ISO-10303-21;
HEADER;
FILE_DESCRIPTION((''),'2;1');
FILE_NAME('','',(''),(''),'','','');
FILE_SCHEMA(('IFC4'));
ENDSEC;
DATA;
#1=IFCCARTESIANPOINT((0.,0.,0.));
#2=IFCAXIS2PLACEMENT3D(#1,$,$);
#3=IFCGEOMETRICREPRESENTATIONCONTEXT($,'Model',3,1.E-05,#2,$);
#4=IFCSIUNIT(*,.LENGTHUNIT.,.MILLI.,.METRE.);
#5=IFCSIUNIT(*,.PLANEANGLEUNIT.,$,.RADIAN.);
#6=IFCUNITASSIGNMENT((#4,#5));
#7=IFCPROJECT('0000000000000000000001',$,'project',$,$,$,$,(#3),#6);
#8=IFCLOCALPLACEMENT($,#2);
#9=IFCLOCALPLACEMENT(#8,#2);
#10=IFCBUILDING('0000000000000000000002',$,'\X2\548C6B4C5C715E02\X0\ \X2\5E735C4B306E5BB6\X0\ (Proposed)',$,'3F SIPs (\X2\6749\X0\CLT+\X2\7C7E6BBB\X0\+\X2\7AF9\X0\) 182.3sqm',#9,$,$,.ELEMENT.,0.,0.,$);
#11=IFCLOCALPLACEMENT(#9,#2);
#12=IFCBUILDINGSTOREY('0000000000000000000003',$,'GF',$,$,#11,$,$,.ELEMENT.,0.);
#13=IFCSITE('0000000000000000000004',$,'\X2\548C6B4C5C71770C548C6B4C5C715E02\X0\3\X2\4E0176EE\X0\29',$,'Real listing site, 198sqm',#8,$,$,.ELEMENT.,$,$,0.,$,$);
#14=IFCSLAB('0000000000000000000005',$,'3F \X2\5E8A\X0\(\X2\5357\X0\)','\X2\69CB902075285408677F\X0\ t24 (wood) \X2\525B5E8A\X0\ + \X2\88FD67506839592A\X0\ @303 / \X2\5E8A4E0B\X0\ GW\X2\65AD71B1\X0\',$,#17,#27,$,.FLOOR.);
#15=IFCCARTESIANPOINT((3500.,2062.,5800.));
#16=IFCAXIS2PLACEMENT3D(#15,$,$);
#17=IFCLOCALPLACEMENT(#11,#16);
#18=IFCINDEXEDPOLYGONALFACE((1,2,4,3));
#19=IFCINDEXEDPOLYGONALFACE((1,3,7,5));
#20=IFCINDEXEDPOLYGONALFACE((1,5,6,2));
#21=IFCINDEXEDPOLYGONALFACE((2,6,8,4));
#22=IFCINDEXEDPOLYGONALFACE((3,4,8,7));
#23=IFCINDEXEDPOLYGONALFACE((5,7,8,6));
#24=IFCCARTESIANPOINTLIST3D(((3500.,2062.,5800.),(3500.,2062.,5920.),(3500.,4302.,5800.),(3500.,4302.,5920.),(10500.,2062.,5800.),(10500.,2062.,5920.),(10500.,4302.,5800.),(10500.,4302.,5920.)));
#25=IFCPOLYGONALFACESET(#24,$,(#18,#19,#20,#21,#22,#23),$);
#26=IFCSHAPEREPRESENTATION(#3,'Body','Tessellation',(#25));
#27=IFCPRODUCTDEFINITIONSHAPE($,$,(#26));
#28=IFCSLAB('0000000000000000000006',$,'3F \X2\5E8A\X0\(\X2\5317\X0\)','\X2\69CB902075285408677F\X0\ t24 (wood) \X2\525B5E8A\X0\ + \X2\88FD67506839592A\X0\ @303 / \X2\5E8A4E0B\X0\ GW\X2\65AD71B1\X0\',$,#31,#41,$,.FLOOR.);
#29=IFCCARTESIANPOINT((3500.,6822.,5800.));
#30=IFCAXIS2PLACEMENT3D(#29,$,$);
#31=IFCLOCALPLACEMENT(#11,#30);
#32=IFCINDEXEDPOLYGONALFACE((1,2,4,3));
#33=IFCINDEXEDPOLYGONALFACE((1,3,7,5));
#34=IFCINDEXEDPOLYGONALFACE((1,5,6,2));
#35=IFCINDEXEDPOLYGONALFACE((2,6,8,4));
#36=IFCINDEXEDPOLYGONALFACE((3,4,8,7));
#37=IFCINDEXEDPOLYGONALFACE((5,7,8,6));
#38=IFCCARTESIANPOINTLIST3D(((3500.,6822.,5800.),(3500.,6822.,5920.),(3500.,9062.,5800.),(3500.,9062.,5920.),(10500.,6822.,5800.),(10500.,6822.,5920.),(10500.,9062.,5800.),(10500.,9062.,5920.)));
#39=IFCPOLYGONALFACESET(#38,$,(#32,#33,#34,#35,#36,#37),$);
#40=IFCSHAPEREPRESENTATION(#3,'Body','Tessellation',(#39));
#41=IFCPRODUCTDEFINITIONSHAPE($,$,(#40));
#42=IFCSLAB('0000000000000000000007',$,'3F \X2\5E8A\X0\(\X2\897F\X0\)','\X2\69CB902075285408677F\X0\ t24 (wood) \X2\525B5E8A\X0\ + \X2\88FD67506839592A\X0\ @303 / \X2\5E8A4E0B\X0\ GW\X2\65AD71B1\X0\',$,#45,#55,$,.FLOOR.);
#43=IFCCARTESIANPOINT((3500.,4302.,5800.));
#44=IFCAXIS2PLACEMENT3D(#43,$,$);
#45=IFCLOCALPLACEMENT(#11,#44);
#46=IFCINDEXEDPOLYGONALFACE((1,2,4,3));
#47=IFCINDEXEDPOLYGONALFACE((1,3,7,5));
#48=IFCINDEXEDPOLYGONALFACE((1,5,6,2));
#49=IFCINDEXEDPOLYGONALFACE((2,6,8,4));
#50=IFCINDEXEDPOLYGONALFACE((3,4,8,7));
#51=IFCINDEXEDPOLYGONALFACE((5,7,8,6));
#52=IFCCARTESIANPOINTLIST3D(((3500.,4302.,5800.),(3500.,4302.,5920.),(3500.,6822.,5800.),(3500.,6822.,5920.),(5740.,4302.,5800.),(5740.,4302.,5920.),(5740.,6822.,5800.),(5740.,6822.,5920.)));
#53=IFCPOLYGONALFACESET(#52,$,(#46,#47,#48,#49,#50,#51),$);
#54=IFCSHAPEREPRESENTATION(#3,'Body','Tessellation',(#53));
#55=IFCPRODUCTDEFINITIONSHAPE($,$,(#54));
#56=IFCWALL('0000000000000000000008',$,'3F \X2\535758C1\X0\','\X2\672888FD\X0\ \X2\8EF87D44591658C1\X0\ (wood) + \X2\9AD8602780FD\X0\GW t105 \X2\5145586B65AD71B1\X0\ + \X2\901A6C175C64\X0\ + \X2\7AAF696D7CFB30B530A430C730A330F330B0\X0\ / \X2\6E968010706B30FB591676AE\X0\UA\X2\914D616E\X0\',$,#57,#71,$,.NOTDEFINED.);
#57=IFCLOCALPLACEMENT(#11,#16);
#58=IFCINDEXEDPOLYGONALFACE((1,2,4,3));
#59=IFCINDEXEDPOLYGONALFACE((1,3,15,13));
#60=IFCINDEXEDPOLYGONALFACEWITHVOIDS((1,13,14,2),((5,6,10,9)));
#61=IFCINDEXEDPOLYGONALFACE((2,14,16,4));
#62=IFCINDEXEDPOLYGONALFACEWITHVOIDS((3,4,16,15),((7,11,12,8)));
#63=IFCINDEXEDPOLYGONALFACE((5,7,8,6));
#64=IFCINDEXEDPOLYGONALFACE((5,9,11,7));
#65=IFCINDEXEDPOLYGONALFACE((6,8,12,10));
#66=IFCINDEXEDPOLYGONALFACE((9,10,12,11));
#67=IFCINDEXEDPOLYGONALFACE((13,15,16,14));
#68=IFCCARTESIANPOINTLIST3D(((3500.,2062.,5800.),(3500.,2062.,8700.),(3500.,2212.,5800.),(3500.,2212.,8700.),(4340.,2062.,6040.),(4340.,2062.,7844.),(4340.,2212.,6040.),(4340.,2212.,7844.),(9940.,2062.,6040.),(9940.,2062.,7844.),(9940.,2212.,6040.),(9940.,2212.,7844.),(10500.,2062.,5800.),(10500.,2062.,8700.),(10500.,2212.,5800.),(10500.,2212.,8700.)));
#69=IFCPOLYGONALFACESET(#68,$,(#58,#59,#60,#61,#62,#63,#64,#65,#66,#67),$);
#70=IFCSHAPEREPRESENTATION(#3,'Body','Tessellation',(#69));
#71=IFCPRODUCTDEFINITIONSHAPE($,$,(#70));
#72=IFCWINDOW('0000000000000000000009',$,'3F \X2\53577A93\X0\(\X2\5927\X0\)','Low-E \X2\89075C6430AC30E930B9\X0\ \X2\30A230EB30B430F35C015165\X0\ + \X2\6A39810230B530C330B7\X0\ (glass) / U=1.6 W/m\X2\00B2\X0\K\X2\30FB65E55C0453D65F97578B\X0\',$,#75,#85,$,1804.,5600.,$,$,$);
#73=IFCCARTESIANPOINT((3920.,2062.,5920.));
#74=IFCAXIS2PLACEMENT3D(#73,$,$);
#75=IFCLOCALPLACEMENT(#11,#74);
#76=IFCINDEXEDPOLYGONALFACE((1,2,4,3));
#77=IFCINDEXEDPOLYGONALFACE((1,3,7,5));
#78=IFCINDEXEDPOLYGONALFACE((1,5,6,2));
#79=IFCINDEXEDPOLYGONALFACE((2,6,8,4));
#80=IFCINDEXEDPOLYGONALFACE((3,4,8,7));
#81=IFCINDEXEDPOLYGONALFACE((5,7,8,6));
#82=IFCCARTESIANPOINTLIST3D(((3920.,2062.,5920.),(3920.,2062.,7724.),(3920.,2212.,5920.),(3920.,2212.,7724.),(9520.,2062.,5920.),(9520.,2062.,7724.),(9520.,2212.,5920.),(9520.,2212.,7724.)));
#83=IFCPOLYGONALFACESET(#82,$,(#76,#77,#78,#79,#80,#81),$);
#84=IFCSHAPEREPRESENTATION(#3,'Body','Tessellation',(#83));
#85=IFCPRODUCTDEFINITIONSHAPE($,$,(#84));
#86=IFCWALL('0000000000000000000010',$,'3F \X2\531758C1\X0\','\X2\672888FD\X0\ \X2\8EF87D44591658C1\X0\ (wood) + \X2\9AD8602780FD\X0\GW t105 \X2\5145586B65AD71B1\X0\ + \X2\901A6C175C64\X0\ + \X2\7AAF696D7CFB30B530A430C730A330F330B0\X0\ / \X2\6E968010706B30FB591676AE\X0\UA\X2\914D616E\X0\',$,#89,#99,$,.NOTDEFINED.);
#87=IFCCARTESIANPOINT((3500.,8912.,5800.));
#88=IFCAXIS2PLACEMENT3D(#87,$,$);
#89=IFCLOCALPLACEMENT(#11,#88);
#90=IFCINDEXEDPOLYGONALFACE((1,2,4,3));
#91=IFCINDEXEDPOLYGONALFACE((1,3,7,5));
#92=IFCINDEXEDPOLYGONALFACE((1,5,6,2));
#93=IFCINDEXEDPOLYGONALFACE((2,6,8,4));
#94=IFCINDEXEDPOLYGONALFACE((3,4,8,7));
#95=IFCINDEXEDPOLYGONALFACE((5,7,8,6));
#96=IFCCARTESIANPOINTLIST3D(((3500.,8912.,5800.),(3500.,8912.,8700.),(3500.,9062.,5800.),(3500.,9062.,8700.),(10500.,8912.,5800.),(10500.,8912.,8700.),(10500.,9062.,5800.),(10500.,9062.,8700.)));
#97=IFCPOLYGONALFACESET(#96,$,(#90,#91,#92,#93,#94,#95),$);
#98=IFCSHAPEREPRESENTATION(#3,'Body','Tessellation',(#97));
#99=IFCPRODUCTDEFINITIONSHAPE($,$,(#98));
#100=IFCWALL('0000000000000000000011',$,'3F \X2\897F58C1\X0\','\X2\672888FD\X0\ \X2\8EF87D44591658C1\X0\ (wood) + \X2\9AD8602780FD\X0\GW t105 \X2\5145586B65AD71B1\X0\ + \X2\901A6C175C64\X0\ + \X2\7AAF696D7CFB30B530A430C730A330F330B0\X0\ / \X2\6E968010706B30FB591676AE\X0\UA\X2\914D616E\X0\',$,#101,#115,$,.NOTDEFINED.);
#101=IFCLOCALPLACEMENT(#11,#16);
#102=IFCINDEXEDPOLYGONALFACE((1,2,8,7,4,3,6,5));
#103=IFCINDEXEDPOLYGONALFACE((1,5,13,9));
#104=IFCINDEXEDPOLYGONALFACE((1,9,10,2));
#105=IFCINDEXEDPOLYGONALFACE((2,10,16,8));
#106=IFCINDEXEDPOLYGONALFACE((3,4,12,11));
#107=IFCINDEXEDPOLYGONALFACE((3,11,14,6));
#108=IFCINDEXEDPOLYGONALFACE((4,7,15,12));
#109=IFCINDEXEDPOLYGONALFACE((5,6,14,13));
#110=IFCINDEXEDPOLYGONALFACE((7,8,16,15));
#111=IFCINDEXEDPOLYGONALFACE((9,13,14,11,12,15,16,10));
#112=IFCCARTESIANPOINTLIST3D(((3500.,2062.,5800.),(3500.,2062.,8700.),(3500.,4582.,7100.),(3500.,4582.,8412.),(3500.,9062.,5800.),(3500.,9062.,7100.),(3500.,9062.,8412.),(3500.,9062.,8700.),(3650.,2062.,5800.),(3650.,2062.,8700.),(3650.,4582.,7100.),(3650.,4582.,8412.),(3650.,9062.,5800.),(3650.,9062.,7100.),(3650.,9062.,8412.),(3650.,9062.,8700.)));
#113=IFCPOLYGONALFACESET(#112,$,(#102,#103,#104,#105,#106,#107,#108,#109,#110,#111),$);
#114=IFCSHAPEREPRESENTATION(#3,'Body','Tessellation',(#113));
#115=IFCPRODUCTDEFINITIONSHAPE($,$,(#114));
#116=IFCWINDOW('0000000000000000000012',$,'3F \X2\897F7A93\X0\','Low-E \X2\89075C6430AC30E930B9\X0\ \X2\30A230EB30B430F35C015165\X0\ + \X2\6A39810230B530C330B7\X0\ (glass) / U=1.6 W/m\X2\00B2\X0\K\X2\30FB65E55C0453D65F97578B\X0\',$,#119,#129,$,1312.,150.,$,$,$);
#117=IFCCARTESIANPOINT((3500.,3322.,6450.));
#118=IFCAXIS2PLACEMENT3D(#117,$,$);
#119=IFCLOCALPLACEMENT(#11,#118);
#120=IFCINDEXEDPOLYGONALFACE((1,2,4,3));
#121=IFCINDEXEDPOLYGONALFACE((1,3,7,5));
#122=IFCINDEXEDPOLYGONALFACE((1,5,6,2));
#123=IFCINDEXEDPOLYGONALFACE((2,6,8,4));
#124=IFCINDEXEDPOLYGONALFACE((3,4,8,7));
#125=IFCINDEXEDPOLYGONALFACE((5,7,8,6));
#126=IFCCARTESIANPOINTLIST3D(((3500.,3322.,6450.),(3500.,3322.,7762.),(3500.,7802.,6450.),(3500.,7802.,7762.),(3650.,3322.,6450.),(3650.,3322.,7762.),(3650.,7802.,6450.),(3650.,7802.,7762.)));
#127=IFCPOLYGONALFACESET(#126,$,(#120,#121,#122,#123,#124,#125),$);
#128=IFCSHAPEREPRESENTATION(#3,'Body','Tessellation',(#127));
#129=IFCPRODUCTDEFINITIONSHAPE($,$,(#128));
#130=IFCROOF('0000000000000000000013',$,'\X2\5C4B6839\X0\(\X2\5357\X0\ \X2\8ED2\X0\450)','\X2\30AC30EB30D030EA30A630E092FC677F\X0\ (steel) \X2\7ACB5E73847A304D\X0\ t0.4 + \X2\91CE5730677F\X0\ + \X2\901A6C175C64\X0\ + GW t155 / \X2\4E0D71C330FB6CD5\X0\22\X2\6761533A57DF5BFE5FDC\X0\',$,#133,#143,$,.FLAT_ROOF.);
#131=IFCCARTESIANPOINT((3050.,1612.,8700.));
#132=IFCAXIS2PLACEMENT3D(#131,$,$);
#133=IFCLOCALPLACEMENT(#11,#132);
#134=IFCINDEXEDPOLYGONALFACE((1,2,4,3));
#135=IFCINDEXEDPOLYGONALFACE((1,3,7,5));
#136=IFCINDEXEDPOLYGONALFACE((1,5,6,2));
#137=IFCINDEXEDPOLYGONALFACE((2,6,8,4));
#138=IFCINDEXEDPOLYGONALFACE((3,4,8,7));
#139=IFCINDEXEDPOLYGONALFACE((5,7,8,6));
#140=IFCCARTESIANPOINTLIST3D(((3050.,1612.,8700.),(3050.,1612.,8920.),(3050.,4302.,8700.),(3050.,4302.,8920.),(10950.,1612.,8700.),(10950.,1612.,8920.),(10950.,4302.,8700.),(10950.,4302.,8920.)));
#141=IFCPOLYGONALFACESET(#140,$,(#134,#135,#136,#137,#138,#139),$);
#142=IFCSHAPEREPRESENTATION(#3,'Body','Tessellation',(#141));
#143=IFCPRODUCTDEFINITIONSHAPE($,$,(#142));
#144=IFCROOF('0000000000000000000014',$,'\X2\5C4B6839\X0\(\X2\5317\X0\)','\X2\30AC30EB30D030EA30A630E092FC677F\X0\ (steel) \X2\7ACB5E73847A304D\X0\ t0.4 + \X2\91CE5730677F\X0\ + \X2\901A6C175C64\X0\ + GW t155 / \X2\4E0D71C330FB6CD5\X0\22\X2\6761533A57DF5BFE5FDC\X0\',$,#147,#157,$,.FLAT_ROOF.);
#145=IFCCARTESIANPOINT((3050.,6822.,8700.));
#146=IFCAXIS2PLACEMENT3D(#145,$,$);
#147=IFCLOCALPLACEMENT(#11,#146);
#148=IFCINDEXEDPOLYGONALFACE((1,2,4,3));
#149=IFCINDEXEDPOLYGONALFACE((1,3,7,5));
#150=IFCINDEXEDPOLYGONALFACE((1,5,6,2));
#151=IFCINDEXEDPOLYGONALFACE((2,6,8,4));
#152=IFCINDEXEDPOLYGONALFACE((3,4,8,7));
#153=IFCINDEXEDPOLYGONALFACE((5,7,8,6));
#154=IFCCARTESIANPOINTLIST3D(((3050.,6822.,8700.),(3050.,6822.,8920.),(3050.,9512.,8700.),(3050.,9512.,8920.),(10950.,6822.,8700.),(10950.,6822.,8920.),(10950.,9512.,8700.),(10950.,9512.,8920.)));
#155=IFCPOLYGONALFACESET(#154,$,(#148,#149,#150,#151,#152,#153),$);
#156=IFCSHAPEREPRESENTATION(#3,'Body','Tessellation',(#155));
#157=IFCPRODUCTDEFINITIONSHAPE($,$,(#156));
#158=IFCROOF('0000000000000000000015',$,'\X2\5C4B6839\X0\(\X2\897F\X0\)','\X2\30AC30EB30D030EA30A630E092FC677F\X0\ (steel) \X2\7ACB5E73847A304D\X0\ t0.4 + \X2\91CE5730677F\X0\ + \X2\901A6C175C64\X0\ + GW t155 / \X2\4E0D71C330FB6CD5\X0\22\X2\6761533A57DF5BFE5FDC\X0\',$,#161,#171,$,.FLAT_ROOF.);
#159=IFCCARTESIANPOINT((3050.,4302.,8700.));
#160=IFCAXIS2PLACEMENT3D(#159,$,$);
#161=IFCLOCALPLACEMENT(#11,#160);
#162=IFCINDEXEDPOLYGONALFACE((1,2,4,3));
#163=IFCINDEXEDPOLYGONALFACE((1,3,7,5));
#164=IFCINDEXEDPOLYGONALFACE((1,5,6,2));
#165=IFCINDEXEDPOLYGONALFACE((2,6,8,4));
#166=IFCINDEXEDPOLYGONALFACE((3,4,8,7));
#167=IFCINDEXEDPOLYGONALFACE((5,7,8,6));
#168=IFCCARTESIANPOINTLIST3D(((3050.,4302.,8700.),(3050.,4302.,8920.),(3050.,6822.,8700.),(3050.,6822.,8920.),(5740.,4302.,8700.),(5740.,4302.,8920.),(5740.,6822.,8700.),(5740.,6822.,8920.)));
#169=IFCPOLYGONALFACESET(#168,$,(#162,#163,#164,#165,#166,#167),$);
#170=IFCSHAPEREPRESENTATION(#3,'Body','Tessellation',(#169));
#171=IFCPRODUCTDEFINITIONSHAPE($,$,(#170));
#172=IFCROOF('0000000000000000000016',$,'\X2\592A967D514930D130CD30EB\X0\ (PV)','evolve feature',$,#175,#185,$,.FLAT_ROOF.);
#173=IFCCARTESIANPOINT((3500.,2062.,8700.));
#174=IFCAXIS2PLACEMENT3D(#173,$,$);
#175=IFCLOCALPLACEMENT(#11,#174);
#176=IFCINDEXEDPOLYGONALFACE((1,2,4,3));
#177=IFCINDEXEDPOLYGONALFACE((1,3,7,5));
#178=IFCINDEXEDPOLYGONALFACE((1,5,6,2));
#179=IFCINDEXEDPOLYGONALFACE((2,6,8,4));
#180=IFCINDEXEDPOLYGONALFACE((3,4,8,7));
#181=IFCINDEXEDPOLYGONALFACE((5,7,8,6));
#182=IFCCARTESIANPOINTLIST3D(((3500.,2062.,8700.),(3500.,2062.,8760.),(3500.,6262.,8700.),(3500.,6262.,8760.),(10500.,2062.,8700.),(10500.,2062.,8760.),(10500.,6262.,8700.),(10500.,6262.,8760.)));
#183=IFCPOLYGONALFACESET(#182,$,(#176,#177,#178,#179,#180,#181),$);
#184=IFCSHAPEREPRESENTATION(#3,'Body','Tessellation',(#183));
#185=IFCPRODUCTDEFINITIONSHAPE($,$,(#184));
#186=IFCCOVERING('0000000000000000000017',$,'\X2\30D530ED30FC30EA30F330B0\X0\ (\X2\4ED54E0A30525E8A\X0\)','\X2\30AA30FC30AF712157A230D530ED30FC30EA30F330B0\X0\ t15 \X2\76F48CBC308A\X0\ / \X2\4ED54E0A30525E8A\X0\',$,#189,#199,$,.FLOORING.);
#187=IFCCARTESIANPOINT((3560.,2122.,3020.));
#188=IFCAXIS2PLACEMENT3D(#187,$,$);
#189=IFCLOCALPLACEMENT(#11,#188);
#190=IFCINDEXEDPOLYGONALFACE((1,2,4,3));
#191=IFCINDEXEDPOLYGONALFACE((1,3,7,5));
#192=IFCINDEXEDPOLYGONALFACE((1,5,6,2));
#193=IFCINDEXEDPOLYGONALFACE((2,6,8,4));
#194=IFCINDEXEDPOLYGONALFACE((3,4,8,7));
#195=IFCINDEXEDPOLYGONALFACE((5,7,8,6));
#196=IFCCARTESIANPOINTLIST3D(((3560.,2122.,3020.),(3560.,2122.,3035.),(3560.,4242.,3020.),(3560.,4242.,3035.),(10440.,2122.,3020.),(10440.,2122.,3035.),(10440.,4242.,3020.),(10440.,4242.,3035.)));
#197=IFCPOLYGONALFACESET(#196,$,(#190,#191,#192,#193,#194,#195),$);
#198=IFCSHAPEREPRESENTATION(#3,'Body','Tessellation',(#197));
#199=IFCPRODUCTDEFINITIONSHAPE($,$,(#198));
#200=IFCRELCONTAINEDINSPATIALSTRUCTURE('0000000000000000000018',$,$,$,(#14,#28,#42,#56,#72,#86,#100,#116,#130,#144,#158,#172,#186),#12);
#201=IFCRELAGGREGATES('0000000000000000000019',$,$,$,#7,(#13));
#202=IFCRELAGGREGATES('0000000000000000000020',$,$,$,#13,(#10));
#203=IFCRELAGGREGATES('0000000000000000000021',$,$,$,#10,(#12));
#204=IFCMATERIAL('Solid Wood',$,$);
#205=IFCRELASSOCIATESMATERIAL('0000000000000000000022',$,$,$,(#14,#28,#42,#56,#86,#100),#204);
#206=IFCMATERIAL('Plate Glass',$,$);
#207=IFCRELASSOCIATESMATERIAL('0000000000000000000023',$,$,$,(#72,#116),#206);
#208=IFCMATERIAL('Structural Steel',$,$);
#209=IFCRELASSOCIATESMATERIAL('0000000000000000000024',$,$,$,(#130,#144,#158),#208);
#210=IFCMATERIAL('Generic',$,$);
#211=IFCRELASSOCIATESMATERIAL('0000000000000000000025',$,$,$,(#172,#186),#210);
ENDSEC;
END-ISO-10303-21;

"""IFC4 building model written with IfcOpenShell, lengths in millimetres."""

from ifc_helpers import new_model, si_unit, frame, frame_2d, origin, place, context, project, spatial, rectangle, extrude, material, element, fill, save


model = new_model("IFC4")

# Units and contexts
model_context = context("Model", 3, precision=1e-05, world=origin())
ifc_project = project(units=[si_unit("LENGTHUNIT", "METRE", prefix="MILLI"), si_unit("PLANEANGLEUNIT", "RADIAN")], contexts=[model_context])

# Site, building, storey
site_placement = place(None, origin())
site = spatial("IfcSite", under=ifc_project, at=site_placement, Name="和歌山県和歌山市3丁目29", ObjectType="Real listing site, 198sqm", CompositionType="ELEMENT", RefElevation=0.0)
building_placement = place(site_placement, origin())
building = spatial("IfcBuilding", under=site, at=building_placement, Name="和歌山市 平屋の家 (Proposed)", ObjectType="3F SIPs (杉CLT+籾殻+竹) 182.3sqm", CompositionType="ELEMENT", ElevationOfRefHeight=0.0, ElevationOfTerrain=0.0)
storey_placement = place(building_placement, origin())
storey = spatial("IfcBuildingStorey", under=building, at=storey_placement, Name="GF", CompositionType="ELEMENT", Elevation=0.0)

# Slabs
ifc_material_1 = material(Name="Solid Wood")
slab_1_placement = place(storey_placement, frame((3500.0, 2062.0, 5800.0)))
element("IfcSlab", 1, at=slab_1_placement, inside=storey, material=ifc_material_1, Name="3F 床(南)", Description="構造用合板 t24 (wood) 剛床 + 製材根太 @303 / 床下 GW断熱", PredefinedType="FLOOR", context=model_context, shape_type="SweptSolid", body=[
    extrude(rectangle(XDim=7000.0, YDim=2240.0, at=frame_2d((3500.0, 1120.0))), frame((3500.0, 2062.0, 5800.0)), (0.0, 0.0, 1.0), 120.0),
])
slab_2_placement = place(storey_placement, frame((3500.0, 6822.0, 5800.0)))
element("IfcSlab", 2, at=slab_2_placement, inside=storey, material=ifc_material_1, Name="3F 床(北)", Description="構造用合板 t24 (wood) 剛床 + 製材根太 @303 / 床下 GW断熱", PredefinedType="FLOOR", context=model_context, shape_type="SweptSolid", body=[
    extrude(rectangle(XDim=7000.0, YDim=2240.0, at=frame_2d((3500.0, 1120.0))), frame((3500.0, 6822.0, 5800.0)), (0.0, 0.0, 1.0), 120.0),
])
slab_3_placement = place(storey_placement, frame((3500.0, 4302.0, 5800.0)))
element("IfcSlab", 3, at=slab_3_placement, inside=storey, material=ifc_material_1, Name="3F 床(西)", Description="構造用合板 t24 (wood) 剛床 + 製材根太 @303 / 床下 GW断熱", PredefinedType="FLOOR", context=model_context, shape_type="SweptSolid", body=[
    extrude(rectangle(XDim=2240.0, YDim=2520.0, at=frame_2d((1120.0, 1260.0))), frame((3500.0, 4302.0, 5800.0)), (0.0, 0.0, 1.0), 120.0),
])

# Wall, opening, window
wall_1_placement = place(storey_placement, frame((3500.0, 2062.0, 5800.0)))
wall_1 = element("IfcWall", 4, at=wall_1_placement, inside=storey, material=ifc_material_1, Name="3F 南壁", Description="木製 軸組外壁 (wood) + 高性能GW t105 充填断熱 + 通気層 + 窯業系サイディング / 準耐火・外皮UA配慮", PredefinedType="NOTDEFINED", context=model_context, shape_type="SweptSolid", body=[
    extrude(rectangle(XDim=7000.0, YDim=150.0, at=frame_2d((3500.0, 75.0))), frame((3500.0, 2062.0, 5800.0)), (0.0, 0.0, 1.0), 2900.0),
])
opening_1_placement = place(storey_placement, frame((3920.0, 2062.0, 5920.0)))
opening_1 = element("IfcOpeningElement", 5, at=opening_1_placement, cuts=wall_1, PredefinedType="NOTDEFINED", context=model_context, shape_type="SweptSolid", body=[
    extrude(rectangle(XDim=5600.0, YDim=150.0, at=frame_2d((2800.0, 75.0))), frame((3920.0, 2062.0, 5920.0)), (0.0, 0.0, 1.0), 1804.0),
])
ifc_material_2 = material(Name="Plate Glass")
window_1_placement = place(storey_placement, frame((3920.0, 2062.0, 5920.0)))
window_1 = element("IfcWindow", 6, at=window_1_placement, inside=storey, material=ifc_material_2, Name="3F 南窓(大)", Description="Low-E 複層ガラス アルゴン封入 + 樹脂サッシ (glass) / U=1.6 W/m²K・日射取得型", OverallHeight=1804.0, OverallWidth=5600.0, context=model_context, shape_type="SweptSolid", body=[
    extrude(rectangle(XDim=5600.0, YDim=150.0, at=frame_2d((2800.0, 75.0))), frame((3920.0, 2062.0, 5920.0)), (0.0, 0.0, 1.0), 1804.0),
])
fill(opening_1, window_1)

# Wall
wall_2_placement = place(storey_placement, frame((3500.0, 8912.0, 5800.0)))
element("IfcWall", 7, at=wall_2_placement, inside=storey, material=ifc_material_1, Name="3F 北壁", Description="木製 軸組外壁 (wood) + 高性能GW t105 充填断熱 + 通気層 + 窯業系サイディング / 準耐火・外皮UA配慮", PredefinedType="NOTDEFINED", context=model_context, shape_type="SweptSolid", body=[
    extrude(rectangle(XDim=7000.0, YDim=150.0, at=frame_2d((3500.0, 75.0))), frame((3500.0, 8912.0, 5800.0)), (0.0, 0.0, 1.0), 2900.0),
])

# Wall, opening, window
wall_3_placement = place(storey_placement, frame((3500.0, 2062.0, 5800.0)))
wall_3 = element("IfcWall", 8, at=wall_3_placement, inside=storey, material=ifc_material_1, Name="3F 西壁", Description="木製 軸組外壁 (wood) + 高性能GW t105 充填断熱 + 通気層 + 窯業系サイディング / 準耐火・外皮UA配慮", PredefinedType="NOTDEFINED", context=model_context, shape_type="SweptSolid", body=[
    extrude(rectangle(XDim=150.0, YDim=7000.0, at=frame_2d((75.0, 3500.0))), frame((3500.0, 2062.0, 5800.0)), (0.0, 0.0, 1.0), 2900.0),
])
opening_2_placement = place(storey_placement, frame((3500.0, 3322.0, 6450.0)))
opening_2 = element("IfcOpeningElement", 9, at=opening_2_placement, cuts=wall_3, PredefinedType="NOTDEFINED", context=model_context, shape_type="SweptSolid", body=[
    extrude(rectangle(XDim=150.0, YDim=4480.0, at=frame_2d((75.0, 2240.0))), frame((3500.0, 3322.0, 6450.0)), (0.0, 0.0, 1.0), 1312.0),
])
window_2_placement = place(storey_placement, frame((3500.0, 3322.0, 6450.0)))
window_2 = element("IfcWindow", 10, at=window_2_placement, inside=storey, material=ifc_material_2, Name="3F 西窓", Description="Low-E 複層ガラス アルゴン封入 + 樹脂サッシ (glass) / U=1.6 W/m²K・日射取得型", OverallHeight=1312.0, OverallWidth=150.0, context=model_context, shape_type="SweptSolid", body=[
    extrude(rectangle(XDim=150.0, YDim=4480.0, at=frame_2d((75.0, 2240.0))), frame((3500.0, 3322.0, 6450.0)), (0.0, 0.0, 1.0), 1312.0),
])
fill(opening_2, window_2)

# Roofs
ifc_material_3 = material(Name="Structural Steel")
roof_1_placement = place(storey_placement, frame((3050.0, 1612.0, 8700.0)))
element("IfcRoof", 11, at=roof_1_placement, inside=storey, material=ifc_material_3, Name="屋根(南 軒450)", Description="ガルバリウム鋼板 (steel) 立平葺き t0.4 + 野地板 + 通気層 + GW t155 / 不燃・法22条区域対応", PredefinedType="FLAT_ROOF", context=model_context, shape_type="SweptSolid", body=[
    extrude(rectangle(XDim=7900.0, YDim=2690.0, at=frame_2d((3950.0, 1345.0))), frame((3050.0, 1612.0, 8700.0)), (0.0, 0.0, 1.0), 220.0),
])
roof_2_placement = place(storey_placement, frame((3050.0, 6822.0, 8700.0)))
element("IfcRoof", 12, at=roof_2_placement, inside=storey, material=ifc_material_3, Name="屋根(北)", Description="ガルバリウム鋼板 (steel) 立平葺き t0.4 + 野地板 + 通気層 + GW t155 / 不燃・法22条区域対応", PredefinedType="FLAT_ROOF", context=model_context, shape_type="SweptSolid", body=[
    extrude(rectangle(XDim=7900.0, YDim=2690.0, at=frame_2d((3950.0, 1345.0))), frame((3050.0, 6822.0, 8700.0)), (0.0, 0.0, 1.0), 220.0),
])
roof_3_placement = place(storey_placement, frame((3050.0, 4302.0, 8700.0)))
element("IfcRoof", 13, at=roof_3_placement, inside=storey, material=ifc_material_3, Name="屋根(西)", Description="ガルバリウム鋼板 (steel) 立平葺き t0.4 + 野地板 + 通気層 + GW t155 / 不燃・法22条区域対応", PredefinedType="FLAT_ROOF", context=model_context, shape_type="SweptSolid", body=[
    extrude(rectangle(XDim=2690.0, YDim=2520.0, at=frame_2d((1345.0, 1260.0))), frame((3050.0, 4302.0, 8700.0)), (0.0, 0.0, 1.0), 220.0),
])
ifc_material_4 = material(Name="Generic")
roof_4_placement = place(storey_placement, frame((3500.0, 2062.0, 8700.0)))
element("IfcRoof", 14, at=roof_4_placement, inside=storey, material=ifc_material_4, Name="太陽光パネル (PV)", Description="evolve feature", PredefinedType="FLAT_ROOF", context=model_context, shape_type="SweptSolid", body=[
    extrude(rectangle(XDim=7000.0, YDim=4200.0, at=frame_2d((3500.0, 2100.0))), frame((3500.0, 2062.0, 8700.0)), (0.0, 0.0, 1.0), 60.0),
])

# Covering
covering_1_placement = place(storey_placement, frame((3560.0, 2122.0, 3020.0)))
element("IfcCovering", 15, at=covering_1_placement, inside=storey, material=ifc_material_4, Name="フローリング (仕上げ床)", Description="オーク無垢フローリング t15 直貼り / 仕上げ床", PredefinedType="FLOORING", context=model_context, shape_type="SweptSolid", body=[
    extrude(rectangle(XDim=6880.0, YDim=2120.0, at=frame_2d((3440.0, 1060.0))), frame((3560.0, 2122.0, 3020.0)), (0.0, 0.0, 1.0), 15.0),
])

save(model, "model.ifc")
